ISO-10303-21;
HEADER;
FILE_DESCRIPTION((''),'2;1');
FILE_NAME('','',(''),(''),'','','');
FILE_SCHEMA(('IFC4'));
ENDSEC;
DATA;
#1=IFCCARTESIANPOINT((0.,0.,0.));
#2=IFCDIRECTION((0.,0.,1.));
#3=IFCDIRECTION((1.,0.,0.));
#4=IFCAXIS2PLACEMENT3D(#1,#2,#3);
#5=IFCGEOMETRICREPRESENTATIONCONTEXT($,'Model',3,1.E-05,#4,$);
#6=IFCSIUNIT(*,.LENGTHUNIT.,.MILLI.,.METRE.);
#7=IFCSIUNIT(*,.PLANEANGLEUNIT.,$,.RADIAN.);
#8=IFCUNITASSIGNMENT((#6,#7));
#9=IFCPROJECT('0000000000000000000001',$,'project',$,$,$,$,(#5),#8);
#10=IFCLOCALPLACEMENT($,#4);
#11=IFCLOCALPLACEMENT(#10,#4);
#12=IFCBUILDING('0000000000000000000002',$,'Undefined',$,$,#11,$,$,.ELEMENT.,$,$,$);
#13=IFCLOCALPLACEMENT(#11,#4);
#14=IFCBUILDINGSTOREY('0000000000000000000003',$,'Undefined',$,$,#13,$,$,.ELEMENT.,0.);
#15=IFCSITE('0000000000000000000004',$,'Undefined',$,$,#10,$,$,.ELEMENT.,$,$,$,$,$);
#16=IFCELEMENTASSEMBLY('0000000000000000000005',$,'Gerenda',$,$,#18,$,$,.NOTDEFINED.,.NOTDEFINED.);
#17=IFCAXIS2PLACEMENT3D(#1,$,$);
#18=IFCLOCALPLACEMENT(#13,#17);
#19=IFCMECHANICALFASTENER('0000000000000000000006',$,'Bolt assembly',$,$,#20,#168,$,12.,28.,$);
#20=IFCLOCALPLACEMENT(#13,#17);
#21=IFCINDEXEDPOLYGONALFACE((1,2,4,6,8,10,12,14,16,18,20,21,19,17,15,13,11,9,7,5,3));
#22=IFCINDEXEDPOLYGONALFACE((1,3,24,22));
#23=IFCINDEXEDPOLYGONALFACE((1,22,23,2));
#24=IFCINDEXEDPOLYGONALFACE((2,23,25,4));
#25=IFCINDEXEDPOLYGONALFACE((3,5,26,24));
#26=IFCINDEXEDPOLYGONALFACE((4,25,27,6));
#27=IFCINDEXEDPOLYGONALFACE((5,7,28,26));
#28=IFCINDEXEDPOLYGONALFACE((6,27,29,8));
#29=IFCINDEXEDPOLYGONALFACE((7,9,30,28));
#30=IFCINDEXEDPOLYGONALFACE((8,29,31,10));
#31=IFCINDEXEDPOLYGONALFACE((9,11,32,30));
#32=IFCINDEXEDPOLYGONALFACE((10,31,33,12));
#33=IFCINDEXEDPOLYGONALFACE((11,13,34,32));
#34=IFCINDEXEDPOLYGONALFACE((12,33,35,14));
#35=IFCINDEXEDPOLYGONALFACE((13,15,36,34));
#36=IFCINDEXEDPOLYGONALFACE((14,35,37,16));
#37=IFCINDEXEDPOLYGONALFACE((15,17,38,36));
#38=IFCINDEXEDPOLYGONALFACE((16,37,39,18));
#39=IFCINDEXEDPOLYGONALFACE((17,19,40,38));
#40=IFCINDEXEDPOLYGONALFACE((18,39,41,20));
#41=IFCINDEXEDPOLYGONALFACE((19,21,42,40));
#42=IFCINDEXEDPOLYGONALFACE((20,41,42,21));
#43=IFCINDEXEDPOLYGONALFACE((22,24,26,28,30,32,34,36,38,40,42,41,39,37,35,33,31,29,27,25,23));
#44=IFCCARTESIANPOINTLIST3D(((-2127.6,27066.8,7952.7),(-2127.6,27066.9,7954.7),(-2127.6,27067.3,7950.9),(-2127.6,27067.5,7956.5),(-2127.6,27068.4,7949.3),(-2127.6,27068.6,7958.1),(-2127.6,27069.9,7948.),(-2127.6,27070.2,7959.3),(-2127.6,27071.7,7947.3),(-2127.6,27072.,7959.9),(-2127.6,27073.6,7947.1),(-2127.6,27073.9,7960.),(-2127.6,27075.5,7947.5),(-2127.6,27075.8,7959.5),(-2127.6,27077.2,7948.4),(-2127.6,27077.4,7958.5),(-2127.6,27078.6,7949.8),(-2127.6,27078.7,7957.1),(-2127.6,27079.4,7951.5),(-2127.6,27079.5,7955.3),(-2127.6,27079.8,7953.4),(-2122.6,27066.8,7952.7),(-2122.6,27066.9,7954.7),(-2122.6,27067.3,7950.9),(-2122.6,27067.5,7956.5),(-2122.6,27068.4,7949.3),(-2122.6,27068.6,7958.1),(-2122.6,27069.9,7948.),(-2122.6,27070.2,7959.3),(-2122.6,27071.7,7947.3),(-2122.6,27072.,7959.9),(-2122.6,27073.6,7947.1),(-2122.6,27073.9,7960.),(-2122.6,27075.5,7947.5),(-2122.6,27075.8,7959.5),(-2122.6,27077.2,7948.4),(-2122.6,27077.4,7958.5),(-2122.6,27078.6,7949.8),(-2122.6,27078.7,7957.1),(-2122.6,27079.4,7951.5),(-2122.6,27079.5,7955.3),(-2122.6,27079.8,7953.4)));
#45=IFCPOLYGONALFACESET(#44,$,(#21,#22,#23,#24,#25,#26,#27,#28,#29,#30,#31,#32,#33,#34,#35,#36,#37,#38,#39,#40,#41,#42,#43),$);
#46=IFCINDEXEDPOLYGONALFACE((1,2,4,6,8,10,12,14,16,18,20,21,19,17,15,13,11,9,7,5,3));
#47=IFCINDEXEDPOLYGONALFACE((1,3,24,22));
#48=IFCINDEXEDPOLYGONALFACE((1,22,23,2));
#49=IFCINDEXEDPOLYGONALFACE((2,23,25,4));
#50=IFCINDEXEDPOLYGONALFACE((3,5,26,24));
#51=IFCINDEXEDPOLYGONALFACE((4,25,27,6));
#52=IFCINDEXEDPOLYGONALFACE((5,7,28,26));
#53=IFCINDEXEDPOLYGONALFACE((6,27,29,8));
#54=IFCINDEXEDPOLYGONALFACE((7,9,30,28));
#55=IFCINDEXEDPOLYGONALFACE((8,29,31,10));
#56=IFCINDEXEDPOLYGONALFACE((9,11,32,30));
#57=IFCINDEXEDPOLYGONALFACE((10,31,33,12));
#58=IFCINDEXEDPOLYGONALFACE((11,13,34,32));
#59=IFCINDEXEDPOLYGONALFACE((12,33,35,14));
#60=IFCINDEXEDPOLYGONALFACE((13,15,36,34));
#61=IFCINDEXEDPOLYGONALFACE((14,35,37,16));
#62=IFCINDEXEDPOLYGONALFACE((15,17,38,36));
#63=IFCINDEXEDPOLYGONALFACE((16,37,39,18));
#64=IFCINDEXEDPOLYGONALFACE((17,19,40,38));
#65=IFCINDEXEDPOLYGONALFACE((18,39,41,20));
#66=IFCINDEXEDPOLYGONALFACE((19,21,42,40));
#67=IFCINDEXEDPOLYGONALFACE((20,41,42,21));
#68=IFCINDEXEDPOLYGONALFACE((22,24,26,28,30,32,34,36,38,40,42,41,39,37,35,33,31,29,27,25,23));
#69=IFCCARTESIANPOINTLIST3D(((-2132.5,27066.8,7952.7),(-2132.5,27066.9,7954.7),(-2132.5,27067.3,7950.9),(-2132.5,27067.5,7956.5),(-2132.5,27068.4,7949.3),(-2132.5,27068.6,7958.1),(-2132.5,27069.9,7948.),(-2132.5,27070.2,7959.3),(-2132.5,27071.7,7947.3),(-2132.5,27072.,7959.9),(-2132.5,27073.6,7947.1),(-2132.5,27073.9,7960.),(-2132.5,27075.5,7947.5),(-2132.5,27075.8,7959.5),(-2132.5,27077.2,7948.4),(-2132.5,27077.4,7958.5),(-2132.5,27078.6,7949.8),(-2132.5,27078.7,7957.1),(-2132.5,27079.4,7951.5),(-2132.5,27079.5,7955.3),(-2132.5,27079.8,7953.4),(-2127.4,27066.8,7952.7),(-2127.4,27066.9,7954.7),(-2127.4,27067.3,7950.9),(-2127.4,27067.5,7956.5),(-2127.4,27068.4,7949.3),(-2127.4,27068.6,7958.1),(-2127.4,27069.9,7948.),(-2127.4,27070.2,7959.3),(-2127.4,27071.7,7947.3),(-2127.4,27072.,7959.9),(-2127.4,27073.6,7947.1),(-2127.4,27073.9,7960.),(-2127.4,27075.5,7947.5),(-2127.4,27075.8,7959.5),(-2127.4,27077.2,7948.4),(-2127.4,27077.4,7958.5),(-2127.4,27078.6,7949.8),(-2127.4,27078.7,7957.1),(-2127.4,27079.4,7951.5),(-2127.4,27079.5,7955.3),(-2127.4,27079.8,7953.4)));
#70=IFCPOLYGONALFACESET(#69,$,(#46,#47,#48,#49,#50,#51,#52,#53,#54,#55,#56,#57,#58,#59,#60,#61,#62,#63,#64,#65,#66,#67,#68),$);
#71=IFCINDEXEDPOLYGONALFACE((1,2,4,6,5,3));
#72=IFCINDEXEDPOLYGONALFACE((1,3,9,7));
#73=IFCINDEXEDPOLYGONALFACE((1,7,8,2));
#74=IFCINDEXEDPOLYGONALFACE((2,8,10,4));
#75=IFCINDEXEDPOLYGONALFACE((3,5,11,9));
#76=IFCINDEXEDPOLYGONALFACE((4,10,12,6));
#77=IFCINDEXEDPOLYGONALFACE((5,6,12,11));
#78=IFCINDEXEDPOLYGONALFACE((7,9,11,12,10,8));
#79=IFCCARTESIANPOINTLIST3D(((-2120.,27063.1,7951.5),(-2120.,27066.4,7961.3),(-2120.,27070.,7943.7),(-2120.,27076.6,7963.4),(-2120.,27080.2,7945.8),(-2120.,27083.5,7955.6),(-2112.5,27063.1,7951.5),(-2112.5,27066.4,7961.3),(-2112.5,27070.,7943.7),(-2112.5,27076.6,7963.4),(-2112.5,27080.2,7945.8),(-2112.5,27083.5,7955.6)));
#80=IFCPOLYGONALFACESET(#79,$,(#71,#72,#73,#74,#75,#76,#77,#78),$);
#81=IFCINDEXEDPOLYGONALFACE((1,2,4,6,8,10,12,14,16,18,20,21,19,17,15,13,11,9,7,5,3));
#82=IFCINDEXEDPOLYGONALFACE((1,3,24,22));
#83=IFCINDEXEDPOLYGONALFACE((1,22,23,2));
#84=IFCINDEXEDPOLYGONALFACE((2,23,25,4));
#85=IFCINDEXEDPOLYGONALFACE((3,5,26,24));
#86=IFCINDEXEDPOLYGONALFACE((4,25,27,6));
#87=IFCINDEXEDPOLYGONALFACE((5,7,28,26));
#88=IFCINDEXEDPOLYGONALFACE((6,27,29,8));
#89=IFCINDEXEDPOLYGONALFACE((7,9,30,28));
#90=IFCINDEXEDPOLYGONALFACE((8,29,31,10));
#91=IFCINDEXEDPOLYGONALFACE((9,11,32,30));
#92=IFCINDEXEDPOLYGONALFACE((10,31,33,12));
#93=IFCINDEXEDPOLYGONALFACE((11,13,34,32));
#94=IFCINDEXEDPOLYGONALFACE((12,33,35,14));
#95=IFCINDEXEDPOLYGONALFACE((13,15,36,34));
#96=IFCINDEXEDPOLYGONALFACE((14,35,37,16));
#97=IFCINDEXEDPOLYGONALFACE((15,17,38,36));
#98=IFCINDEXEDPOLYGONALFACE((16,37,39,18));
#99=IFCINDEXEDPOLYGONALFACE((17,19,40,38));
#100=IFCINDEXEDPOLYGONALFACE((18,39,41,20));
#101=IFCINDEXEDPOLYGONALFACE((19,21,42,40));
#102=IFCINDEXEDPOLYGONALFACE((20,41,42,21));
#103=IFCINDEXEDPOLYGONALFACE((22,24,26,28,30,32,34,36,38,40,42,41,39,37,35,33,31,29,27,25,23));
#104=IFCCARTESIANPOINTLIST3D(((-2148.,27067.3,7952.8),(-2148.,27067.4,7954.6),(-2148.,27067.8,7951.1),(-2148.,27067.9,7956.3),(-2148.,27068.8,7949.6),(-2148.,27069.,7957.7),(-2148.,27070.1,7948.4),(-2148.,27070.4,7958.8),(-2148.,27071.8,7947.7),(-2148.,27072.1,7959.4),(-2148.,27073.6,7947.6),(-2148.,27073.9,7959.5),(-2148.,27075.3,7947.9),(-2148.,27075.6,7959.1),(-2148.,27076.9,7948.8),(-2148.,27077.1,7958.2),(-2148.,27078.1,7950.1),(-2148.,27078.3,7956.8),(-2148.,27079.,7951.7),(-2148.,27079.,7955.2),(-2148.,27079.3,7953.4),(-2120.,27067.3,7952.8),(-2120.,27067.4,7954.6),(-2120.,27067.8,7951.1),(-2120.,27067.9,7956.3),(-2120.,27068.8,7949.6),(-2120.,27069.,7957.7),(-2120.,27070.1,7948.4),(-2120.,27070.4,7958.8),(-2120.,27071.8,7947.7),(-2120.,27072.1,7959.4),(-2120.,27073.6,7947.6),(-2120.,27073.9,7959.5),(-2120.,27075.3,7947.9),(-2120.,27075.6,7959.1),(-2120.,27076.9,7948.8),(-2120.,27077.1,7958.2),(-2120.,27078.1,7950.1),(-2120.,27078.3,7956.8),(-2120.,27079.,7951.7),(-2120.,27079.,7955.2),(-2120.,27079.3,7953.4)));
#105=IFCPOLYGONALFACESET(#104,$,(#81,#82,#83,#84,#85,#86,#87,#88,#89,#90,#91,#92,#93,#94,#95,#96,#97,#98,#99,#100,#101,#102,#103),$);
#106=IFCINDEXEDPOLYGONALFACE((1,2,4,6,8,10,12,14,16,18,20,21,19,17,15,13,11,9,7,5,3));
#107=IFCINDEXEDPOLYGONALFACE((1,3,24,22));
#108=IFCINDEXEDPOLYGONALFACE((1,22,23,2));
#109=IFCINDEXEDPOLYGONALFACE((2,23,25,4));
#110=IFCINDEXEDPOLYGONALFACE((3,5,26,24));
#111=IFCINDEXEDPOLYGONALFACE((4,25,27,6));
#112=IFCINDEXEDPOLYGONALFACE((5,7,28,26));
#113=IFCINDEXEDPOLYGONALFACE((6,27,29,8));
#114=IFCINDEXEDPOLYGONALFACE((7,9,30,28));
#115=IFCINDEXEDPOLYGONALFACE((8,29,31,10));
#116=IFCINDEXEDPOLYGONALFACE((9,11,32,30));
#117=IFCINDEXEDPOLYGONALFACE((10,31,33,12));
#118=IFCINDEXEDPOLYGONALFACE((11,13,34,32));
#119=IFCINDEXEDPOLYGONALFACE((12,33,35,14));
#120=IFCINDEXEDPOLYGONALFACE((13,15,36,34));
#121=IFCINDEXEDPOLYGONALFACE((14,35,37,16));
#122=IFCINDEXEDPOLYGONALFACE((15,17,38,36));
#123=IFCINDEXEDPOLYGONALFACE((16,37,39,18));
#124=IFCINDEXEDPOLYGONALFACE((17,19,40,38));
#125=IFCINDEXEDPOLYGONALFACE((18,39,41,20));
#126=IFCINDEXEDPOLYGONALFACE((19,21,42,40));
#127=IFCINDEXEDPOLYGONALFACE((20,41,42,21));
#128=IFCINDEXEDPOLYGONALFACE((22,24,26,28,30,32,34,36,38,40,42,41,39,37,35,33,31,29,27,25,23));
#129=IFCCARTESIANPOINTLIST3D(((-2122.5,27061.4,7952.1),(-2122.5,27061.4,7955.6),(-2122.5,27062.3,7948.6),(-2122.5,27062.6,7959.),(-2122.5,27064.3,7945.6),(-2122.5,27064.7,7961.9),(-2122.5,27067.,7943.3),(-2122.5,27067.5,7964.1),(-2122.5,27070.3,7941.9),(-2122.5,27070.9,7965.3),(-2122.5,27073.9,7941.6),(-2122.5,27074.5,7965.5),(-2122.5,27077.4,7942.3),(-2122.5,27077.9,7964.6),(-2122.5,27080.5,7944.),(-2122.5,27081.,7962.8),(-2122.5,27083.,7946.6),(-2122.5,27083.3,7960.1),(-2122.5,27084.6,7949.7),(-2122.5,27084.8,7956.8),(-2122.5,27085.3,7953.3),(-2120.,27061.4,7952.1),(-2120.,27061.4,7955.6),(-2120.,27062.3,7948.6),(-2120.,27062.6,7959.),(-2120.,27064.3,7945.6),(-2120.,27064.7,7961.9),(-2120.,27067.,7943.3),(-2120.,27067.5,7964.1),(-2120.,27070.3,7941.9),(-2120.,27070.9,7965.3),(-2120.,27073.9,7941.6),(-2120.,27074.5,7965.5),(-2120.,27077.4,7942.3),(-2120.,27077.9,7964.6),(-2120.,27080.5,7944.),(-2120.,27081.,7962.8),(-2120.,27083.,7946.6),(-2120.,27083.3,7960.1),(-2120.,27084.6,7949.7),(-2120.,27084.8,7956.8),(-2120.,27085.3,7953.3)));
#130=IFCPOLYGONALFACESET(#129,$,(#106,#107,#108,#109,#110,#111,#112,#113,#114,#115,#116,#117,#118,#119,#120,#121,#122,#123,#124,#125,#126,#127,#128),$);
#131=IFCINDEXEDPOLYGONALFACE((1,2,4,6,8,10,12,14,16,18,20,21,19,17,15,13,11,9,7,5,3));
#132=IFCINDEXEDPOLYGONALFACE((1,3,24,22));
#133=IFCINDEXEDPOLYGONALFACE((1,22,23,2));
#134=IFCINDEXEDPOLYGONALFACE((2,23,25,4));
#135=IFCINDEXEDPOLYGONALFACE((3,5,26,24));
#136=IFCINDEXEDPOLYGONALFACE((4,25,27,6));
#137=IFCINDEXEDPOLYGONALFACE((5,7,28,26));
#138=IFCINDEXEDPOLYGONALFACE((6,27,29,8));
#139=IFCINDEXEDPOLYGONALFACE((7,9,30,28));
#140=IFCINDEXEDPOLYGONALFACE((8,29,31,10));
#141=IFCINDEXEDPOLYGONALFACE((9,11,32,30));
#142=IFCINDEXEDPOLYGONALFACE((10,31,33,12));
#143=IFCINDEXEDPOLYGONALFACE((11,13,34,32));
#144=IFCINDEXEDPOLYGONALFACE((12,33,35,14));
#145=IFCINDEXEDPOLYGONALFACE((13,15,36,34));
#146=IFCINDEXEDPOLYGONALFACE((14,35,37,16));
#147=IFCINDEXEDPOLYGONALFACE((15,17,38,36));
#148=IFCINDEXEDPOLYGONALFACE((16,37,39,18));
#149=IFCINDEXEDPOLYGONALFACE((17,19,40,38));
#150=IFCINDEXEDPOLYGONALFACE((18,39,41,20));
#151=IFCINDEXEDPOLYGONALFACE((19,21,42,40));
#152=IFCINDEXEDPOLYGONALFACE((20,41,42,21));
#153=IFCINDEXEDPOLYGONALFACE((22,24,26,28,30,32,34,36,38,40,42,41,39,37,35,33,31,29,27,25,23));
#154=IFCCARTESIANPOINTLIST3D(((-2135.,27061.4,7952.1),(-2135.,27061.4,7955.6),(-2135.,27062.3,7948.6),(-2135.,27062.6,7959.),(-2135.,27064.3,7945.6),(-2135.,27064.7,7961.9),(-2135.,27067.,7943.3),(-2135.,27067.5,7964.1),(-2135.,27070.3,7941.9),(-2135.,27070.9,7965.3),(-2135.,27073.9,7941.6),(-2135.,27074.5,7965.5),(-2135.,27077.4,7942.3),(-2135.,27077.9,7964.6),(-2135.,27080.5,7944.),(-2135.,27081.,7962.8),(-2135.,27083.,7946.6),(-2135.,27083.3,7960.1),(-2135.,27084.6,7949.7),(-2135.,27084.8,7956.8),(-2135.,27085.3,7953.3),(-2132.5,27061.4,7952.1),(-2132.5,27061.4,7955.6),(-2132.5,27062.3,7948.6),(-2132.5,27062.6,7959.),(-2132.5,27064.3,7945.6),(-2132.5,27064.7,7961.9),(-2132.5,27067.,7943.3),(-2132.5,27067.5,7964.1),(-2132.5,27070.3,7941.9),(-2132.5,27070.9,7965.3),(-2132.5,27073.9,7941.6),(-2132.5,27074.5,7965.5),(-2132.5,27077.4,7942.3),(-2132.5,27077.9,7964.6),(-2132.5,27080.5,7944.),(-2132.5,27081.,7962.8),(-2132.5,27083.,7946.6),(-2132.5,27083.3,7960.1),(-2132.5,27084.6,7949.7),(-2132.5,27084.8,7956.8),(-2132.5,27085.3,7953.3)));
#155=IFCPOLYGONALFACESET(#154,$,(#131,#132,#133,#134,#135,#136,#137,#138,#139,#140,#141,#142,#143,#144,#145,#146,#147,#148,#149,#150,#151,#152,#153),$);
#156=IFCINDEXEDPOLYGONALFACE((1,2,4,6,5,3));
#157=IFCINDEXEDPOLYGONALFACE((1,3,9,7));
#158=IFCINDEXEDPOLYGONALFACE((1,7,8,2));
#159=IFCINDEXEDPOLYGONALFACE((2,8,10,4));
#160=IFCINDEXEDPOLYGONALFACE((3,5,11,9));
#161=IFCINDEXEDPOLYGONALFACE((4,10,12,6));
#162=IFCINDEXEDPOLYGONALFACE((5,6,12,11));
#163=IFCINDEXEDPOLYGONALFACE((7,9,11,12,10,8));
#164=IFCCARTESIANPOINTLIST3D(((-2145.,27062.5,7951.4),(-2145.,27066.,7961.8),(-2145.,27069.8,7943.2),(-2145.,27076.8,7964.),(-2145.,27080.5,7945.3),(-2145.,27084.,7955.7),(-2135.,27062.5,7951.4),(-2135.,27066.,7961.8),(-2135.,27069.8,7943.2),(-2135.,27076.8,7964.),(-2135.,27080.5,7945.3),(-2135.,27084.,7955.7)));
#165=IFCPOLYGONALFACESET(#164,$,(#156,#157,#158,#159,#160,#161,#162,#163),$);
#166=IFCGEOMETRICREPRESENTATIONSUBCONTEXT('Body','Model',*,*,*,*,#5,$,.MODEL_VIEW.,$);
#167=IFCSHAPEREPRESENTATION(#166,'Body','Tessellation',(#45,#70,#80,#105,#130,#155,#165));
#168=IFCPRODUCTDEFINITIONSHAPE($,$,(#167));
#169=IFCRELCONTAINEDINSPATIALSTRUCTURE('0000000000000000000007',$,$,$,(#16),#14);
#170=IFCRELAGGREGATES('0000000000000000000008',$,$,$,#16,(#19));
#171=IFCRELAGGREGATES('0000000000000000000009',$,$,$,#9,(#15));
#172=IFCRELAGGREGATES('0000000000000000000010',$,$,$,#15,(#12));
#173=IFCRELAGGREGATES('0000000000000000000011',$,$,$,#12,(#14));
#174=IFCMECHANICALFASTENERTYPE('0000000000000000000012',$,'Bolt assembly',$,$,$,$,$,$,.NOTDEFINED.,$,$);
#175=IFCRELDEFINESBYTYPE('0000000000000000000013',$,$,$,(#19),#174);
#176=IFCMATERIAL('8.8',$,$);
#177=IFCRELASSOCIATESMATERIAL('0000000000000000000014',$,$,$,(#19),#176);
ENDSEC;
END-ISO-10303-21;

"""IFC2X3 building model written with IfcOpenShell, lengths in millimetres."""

from ifc_helpers import new_model, si_unit, frame, origin_with_axes, origin_2d_with_axis, place, context, subcontext, project, spatial, polyline, circle, outline, extrude, source, transform, mapped, material, type_object, element, aggregate, save


model = new_model("IFC2X3")

# Units and contexts
model_context = context("Model", 3, precision=1e-05, world=origin_with_axes())
body_context = subcontext(model_context, "Body", "Model", "MODEL_VIEW")
ifc_project = project(units=[si_unit("LENGTHUNIT", "METRE", prefix="MILLI"), si_unit("PLANEANGLEUNIT", "RADIAN")], contexts=[model_context])

# Site, building, storey
site_placement = place(None, origin_with_axes())
site = spatial("IfcSite", under=ifc_project, at=site_placement, Name="Undefined", CompositionType="ELEMENT")
building_placement = place(site_placement, origin_with_axes())
building = spatial("IfcBuilding", under=site, at=building_placement, Name="Undefined", CompositionType="ELEMENT")
storey_placement = place(building_placement, origin_with_axes())
storey = spatial("IfcBuildingStorey", under=building, at=storey_placement, Name="Undefined", CompositionType="ELEMENT", Elevation=0.0)

# Element assembly
assembly_1_placement = place(storey_placement, origin_with_axes())
assembly_1 = element("IfcElementAssembly", 1, at=assembly_1_placement, inside=storey, Name="Gerenda", AssemblyPlace="NOTDEFINED", PredefinedType="NOTDEFINED")

# Mechanical fastener
ifc_material_1 = material(Name="8.8")
mechanical_fastener_type = type_object("IfcMechanicalFastenerType", Name="Bolt assembly")
shared_shape_1 = source(origin_with_axes(), body_context, "Body", "SweptSolid", [
    extrude(circle(Radius=6.5, at=origin_2d_with_axis()), frame((0.0, -7.4, 0.0), z_axis=(0.0, 1.0, 0.0), x_axis=(1.0, 0.0, 0.0)), (0.0, 0.0, 1.0), 5.0),
    extrude(circle(Radius=6.5, at=origin_2d_with_axis()), frame((0.0, -2.6, 0.0), z_axis=(0.0, 1.0, 0.0), x_axis=(1.0, 0.0, 0.0)), (0.0, 0.0, 1.0), 5.1),
    extrude(outline(polyline([(9.0, -5.2), (9.0, 5.2), (0.0, 10.4), (-9.0, 5.2), (-9.0, -5.2), (0.0, -10.4), (9.0, -5.2)])), frame((0.0, -17.5, 0.0), z_axis=(0.0, 1.0, 0.0), x_axis=(1.0, 0.0, 0.0)), (0.0, 0.0, 1.0), 7.5),
    extrude(circle(Radius=6.0, at=origin_2d_with_axis()), frame((0.0, -10.0, 0.0), z_axis=(0.0, 1.0, 0.0), x_axis=(1.0, 0.0, 0.0)), (0.0, 0.0, 1.0), 28.0),
    extrude(circle(Radius=12.0, at=origin_2d_with_axis()), frame((0.0, -10.0, 0.0), z_axis=(0.0, 1.0, 0.0), x_axis=(1.0, 0.0, 0.0)), (0.0, 0.0, 1.0), 2.5),
    extrude(circle(Radius=12.0, at=origin_2d_with_axis()), frame((0.0, 2.5, 0.0), z_axis=(0.0, 1.0, 0.0), x_axis=(1.0, 0.0, 0.0)), (0.0, 0.0, 1.0), 2.5),
    extrude(outline(polyline([(9.5, -5.5), (9.5, 5.5), (0.0, 11.0), (-9.5, 5.5), (-9.5, -5.5), (0.0, -11.0), (9.5, -5.5)])), frame((0.0, 5.0, 0.0), z_axis=(0.0, 1.0, 0.0), x_axis=(1.0, 0.0, 0.0)), (0.0, 0.0, 1.0), 10.0),
])
mechanical_fastener_1_placement = place(assembly_1_placement, frame((-2130.0, 27073.3, 7953.6), z_axis=(0.000003, 0.662403, -0.749147), x_axis=(-0.000003, -0.749147, -0.662403)))
mechanical_fastener_1 = element("IfcMechanicalFastener", 2, at=mechanical_fastener_1_placement, type_object=mechanical_fastener_type, material=ifc_material_1, Name="Bolt assembly", NominalDiameter=12.0, NominalLength=28.0, context=body_context, shape_type="MappedRepresentation", body=[
    mapped(shared_shape_1, transform((0.0, 0.0, 0.0))),
])
aggregate(assembly_1, [mechanical_fastener_1])

save(model, "model.ifc")
